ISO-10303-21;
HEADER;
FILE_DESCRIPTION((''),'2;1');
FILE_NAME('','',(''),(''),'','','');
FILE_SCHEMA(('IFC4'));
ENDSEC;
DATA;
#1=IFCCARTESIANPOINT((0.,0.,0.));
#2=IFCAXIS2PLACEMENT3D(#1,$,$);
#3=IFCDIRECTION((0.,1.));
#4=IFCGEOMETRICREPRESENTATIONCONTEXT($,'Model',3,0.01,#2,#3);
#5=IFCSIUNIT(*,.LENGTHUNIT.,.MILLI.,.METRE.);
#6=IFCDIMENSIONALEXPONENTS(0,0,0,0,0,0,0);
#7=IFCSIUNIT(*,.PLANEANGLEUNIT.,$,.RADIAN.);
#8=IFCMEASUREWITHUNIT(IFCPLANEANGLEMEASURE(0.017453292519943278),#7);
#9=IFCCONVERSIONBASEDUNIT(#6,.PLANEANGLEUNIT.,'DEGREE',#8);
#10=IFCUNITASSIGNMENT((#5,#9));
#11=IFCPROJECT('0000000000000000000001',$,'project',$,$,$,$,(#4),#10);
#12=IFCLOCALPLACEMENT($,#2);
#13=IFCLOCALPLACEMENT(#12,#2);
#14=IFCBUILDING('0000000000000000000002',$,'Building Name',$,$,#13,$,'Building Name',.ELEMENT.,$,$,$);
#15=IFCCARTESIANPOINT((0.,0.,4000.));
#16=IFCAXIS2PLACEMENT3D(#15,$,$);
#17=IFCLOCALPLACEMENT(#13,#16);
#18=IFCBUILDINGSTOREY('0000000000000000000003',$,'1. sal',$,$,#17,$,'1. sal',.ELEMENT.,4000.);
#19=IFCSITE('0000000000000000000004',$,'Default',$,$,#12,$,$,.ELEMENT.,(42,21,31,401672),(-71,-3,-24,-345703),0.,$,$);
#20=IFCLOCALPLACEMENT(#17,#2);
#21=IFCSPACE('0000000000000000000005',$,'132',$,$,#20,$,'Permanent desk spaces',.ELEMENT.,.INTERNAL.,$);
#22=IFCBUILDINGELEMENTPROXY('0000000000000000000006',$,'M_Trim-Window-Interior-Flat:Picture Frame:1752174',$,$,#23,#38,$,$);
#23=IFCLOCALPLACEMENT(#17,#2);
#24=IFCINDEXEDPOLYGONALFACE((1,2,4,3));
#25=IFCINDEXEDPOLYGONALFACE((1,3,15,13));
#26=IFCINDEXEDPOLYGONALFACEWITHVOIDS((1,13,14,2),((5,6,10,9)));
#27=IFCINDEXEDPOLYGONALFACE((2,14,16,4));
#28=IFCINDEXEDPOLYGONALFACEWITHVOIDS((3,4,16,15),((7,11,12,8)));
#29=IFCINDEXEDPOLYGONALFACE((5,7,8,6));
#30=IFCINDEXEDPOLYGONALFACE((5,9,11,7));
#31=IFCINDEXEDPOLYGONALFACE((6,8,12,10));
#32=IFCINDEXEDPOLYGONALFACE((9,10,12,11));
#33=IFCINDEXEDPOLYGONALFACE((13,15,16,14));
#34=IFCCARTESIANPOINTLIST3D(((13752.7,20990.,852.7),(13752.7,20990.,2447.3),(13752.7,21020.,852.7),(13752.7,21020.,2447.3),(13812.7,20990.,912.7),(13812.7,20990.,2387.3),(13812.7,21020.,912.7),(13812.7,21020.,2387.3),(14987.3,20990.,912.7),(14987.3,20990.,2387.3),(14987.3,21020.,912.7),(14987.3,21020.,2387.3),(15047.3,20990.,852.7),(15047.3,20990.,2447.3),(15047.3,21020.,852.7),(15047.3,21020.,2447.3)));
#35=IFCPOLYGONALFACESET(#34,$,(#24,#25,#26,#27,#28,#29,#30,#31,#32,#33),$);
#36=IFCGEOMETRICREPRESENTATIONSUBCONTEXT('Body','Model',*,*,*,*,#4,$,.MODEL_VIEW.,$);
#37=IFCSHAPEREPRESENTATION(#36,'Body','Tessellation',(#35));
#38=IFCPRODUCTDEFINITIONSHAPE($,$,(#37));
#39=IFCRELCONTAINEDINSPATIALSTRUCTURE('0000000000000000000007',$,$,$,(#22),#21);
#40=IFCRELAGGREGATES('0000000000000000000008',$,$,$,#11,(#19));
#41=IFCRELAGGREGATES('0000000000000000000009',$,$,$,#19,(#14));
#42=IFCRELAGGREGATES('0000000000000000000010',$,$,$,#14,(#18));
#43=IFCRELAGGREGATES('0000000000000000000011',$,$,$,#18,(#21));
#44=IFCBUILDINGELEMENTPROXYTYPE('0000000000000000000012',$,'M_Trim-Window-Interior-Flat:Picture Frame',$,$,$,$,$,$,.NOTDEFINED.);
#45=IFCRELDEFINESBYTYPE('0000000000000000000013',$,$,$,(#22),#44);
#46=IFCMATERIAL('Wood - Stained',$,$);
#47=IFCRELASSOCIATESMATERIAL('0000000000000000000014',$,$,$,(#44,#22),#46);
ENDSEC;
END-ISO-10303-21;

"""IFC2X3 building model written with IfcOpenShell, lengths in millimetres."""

from ifc_helpers import new_model, entity, si_unit, converted_unit, direction, frame, origin, place, context, subcontext, project, spatial, polyline, outline, extrude, source, transform, mapped, material, type_object, type_shapes, element, save


model = new_model("IFC2X3")

# Units and contexts
model_context = context("Model", 3, precision=0.01, world=origin(), true_north=direction((0.0, 1.0)))
body_context = subcontext(model_context, "Body", "Model", "MODEL_VIEW")
ifc_project = project(units=[si_unit("LENGTHUNIT", "METRE", prefix="MILLI"), converted_unit("PLANEANGLEUNIT", "DEGREE", entity("IfcPlaneAngleMeasure", 0.017453292519943278), si_unit("PLANEANGLEUNIT", "RADIAN"), dimensions=[0, 0, 0, 0, 0, 0, 0])], contexts=[model_context])

# Site, building, storey
site_placement = place(None, origin())
site = spatial("IfcSite", under=ifc_project, at=site_placement, Name="Default", CompositionType="ELEMENT", RefLatitude=(42, 21, 31, 401672), RefLongitude=(-71, -3, -24, -345703), RefElevation=0.0)
building_placement = place(site_placement, origin())
building = spatial("IfcBuilding", under=site, at=building_placement, Name="Building Name", LongName="Building Name", CompositionType="ELEMENT")
storey_placement = place(building_placement, frame((0.0, 0.0, 4000.0)))
storey = spatial("IfcBuildingStorey", under=building, at=storey_placement, Name="1. sal", LongName="1. sal", CompositionType="ELEMENT", Elevation=4000.0)

# Shared definitions
ifc_material_1 = material(Name="Wood - Stained")

# Shared definitions
space_placement = place(storey_placement, origin())
space = spatial("IfcSpace", under=storey, at=space_placement, Name="132", LongName="Permanent desk spaces", CompositionType="ELEMENT", InteriorOrExteriorSpace="INTERNAL")

# Building element proxy
building_element_proxy_type_1 = type_object("IfcBuildingElementProxyType", Name="M_Trim-Window-Interior-Flat:Picture Frame", PredefinedType="NOTDEFINED", material=ifc_material_1)
shared_shape_1 = source(origin(), body_context, "Body", "SweptSolid", [
    extrude(outline(polyline([(-647.3, -797.3), (647.3, -797.3), (647.3, 797.3), (-647.3, 797.3), (-647.3, -797.3)]), holes=[polyline([(-587.3, -737.3), (-587.3, 737.3), (587.3, 737.3), (587.3, -737.3), (-587.3, -737.3)])]), frame((0.0, -750.0, 0.0), z_axis=(0.0, 0.0, 1.0), x_axis=(-1.0, 0.0, 0.0)), (0.0, 0.0, 1.0), 30.0),
])
type_shapes(building_element_proxy_type_1, [shared_shape_1])
for number, where, z_axis, x_axis, name in (
    (1, (14400.0, 21020.0, 2400.0), (0.0, -1.0, 0.0), (1.0, 0.0, 0.0), "M_Trim-Window-Interior-Flat:Picture Frame:1752174"),
):
    element("IfcBuildingElementProxy", number, at=place(space_placement, frame(where, z_axis=z_axis, x_axis=x_axis)), inside=space, type_object=building_element_proxy_type_1, material=ifc_material_1, Name=name, context=body_context, shape_type="MappedRepresentation", body=[
        mapped(shared_shape_1, transform((0.0, 0.0, 0.0), scale=1.0)),
    ])

save(model, "model.ifc")
